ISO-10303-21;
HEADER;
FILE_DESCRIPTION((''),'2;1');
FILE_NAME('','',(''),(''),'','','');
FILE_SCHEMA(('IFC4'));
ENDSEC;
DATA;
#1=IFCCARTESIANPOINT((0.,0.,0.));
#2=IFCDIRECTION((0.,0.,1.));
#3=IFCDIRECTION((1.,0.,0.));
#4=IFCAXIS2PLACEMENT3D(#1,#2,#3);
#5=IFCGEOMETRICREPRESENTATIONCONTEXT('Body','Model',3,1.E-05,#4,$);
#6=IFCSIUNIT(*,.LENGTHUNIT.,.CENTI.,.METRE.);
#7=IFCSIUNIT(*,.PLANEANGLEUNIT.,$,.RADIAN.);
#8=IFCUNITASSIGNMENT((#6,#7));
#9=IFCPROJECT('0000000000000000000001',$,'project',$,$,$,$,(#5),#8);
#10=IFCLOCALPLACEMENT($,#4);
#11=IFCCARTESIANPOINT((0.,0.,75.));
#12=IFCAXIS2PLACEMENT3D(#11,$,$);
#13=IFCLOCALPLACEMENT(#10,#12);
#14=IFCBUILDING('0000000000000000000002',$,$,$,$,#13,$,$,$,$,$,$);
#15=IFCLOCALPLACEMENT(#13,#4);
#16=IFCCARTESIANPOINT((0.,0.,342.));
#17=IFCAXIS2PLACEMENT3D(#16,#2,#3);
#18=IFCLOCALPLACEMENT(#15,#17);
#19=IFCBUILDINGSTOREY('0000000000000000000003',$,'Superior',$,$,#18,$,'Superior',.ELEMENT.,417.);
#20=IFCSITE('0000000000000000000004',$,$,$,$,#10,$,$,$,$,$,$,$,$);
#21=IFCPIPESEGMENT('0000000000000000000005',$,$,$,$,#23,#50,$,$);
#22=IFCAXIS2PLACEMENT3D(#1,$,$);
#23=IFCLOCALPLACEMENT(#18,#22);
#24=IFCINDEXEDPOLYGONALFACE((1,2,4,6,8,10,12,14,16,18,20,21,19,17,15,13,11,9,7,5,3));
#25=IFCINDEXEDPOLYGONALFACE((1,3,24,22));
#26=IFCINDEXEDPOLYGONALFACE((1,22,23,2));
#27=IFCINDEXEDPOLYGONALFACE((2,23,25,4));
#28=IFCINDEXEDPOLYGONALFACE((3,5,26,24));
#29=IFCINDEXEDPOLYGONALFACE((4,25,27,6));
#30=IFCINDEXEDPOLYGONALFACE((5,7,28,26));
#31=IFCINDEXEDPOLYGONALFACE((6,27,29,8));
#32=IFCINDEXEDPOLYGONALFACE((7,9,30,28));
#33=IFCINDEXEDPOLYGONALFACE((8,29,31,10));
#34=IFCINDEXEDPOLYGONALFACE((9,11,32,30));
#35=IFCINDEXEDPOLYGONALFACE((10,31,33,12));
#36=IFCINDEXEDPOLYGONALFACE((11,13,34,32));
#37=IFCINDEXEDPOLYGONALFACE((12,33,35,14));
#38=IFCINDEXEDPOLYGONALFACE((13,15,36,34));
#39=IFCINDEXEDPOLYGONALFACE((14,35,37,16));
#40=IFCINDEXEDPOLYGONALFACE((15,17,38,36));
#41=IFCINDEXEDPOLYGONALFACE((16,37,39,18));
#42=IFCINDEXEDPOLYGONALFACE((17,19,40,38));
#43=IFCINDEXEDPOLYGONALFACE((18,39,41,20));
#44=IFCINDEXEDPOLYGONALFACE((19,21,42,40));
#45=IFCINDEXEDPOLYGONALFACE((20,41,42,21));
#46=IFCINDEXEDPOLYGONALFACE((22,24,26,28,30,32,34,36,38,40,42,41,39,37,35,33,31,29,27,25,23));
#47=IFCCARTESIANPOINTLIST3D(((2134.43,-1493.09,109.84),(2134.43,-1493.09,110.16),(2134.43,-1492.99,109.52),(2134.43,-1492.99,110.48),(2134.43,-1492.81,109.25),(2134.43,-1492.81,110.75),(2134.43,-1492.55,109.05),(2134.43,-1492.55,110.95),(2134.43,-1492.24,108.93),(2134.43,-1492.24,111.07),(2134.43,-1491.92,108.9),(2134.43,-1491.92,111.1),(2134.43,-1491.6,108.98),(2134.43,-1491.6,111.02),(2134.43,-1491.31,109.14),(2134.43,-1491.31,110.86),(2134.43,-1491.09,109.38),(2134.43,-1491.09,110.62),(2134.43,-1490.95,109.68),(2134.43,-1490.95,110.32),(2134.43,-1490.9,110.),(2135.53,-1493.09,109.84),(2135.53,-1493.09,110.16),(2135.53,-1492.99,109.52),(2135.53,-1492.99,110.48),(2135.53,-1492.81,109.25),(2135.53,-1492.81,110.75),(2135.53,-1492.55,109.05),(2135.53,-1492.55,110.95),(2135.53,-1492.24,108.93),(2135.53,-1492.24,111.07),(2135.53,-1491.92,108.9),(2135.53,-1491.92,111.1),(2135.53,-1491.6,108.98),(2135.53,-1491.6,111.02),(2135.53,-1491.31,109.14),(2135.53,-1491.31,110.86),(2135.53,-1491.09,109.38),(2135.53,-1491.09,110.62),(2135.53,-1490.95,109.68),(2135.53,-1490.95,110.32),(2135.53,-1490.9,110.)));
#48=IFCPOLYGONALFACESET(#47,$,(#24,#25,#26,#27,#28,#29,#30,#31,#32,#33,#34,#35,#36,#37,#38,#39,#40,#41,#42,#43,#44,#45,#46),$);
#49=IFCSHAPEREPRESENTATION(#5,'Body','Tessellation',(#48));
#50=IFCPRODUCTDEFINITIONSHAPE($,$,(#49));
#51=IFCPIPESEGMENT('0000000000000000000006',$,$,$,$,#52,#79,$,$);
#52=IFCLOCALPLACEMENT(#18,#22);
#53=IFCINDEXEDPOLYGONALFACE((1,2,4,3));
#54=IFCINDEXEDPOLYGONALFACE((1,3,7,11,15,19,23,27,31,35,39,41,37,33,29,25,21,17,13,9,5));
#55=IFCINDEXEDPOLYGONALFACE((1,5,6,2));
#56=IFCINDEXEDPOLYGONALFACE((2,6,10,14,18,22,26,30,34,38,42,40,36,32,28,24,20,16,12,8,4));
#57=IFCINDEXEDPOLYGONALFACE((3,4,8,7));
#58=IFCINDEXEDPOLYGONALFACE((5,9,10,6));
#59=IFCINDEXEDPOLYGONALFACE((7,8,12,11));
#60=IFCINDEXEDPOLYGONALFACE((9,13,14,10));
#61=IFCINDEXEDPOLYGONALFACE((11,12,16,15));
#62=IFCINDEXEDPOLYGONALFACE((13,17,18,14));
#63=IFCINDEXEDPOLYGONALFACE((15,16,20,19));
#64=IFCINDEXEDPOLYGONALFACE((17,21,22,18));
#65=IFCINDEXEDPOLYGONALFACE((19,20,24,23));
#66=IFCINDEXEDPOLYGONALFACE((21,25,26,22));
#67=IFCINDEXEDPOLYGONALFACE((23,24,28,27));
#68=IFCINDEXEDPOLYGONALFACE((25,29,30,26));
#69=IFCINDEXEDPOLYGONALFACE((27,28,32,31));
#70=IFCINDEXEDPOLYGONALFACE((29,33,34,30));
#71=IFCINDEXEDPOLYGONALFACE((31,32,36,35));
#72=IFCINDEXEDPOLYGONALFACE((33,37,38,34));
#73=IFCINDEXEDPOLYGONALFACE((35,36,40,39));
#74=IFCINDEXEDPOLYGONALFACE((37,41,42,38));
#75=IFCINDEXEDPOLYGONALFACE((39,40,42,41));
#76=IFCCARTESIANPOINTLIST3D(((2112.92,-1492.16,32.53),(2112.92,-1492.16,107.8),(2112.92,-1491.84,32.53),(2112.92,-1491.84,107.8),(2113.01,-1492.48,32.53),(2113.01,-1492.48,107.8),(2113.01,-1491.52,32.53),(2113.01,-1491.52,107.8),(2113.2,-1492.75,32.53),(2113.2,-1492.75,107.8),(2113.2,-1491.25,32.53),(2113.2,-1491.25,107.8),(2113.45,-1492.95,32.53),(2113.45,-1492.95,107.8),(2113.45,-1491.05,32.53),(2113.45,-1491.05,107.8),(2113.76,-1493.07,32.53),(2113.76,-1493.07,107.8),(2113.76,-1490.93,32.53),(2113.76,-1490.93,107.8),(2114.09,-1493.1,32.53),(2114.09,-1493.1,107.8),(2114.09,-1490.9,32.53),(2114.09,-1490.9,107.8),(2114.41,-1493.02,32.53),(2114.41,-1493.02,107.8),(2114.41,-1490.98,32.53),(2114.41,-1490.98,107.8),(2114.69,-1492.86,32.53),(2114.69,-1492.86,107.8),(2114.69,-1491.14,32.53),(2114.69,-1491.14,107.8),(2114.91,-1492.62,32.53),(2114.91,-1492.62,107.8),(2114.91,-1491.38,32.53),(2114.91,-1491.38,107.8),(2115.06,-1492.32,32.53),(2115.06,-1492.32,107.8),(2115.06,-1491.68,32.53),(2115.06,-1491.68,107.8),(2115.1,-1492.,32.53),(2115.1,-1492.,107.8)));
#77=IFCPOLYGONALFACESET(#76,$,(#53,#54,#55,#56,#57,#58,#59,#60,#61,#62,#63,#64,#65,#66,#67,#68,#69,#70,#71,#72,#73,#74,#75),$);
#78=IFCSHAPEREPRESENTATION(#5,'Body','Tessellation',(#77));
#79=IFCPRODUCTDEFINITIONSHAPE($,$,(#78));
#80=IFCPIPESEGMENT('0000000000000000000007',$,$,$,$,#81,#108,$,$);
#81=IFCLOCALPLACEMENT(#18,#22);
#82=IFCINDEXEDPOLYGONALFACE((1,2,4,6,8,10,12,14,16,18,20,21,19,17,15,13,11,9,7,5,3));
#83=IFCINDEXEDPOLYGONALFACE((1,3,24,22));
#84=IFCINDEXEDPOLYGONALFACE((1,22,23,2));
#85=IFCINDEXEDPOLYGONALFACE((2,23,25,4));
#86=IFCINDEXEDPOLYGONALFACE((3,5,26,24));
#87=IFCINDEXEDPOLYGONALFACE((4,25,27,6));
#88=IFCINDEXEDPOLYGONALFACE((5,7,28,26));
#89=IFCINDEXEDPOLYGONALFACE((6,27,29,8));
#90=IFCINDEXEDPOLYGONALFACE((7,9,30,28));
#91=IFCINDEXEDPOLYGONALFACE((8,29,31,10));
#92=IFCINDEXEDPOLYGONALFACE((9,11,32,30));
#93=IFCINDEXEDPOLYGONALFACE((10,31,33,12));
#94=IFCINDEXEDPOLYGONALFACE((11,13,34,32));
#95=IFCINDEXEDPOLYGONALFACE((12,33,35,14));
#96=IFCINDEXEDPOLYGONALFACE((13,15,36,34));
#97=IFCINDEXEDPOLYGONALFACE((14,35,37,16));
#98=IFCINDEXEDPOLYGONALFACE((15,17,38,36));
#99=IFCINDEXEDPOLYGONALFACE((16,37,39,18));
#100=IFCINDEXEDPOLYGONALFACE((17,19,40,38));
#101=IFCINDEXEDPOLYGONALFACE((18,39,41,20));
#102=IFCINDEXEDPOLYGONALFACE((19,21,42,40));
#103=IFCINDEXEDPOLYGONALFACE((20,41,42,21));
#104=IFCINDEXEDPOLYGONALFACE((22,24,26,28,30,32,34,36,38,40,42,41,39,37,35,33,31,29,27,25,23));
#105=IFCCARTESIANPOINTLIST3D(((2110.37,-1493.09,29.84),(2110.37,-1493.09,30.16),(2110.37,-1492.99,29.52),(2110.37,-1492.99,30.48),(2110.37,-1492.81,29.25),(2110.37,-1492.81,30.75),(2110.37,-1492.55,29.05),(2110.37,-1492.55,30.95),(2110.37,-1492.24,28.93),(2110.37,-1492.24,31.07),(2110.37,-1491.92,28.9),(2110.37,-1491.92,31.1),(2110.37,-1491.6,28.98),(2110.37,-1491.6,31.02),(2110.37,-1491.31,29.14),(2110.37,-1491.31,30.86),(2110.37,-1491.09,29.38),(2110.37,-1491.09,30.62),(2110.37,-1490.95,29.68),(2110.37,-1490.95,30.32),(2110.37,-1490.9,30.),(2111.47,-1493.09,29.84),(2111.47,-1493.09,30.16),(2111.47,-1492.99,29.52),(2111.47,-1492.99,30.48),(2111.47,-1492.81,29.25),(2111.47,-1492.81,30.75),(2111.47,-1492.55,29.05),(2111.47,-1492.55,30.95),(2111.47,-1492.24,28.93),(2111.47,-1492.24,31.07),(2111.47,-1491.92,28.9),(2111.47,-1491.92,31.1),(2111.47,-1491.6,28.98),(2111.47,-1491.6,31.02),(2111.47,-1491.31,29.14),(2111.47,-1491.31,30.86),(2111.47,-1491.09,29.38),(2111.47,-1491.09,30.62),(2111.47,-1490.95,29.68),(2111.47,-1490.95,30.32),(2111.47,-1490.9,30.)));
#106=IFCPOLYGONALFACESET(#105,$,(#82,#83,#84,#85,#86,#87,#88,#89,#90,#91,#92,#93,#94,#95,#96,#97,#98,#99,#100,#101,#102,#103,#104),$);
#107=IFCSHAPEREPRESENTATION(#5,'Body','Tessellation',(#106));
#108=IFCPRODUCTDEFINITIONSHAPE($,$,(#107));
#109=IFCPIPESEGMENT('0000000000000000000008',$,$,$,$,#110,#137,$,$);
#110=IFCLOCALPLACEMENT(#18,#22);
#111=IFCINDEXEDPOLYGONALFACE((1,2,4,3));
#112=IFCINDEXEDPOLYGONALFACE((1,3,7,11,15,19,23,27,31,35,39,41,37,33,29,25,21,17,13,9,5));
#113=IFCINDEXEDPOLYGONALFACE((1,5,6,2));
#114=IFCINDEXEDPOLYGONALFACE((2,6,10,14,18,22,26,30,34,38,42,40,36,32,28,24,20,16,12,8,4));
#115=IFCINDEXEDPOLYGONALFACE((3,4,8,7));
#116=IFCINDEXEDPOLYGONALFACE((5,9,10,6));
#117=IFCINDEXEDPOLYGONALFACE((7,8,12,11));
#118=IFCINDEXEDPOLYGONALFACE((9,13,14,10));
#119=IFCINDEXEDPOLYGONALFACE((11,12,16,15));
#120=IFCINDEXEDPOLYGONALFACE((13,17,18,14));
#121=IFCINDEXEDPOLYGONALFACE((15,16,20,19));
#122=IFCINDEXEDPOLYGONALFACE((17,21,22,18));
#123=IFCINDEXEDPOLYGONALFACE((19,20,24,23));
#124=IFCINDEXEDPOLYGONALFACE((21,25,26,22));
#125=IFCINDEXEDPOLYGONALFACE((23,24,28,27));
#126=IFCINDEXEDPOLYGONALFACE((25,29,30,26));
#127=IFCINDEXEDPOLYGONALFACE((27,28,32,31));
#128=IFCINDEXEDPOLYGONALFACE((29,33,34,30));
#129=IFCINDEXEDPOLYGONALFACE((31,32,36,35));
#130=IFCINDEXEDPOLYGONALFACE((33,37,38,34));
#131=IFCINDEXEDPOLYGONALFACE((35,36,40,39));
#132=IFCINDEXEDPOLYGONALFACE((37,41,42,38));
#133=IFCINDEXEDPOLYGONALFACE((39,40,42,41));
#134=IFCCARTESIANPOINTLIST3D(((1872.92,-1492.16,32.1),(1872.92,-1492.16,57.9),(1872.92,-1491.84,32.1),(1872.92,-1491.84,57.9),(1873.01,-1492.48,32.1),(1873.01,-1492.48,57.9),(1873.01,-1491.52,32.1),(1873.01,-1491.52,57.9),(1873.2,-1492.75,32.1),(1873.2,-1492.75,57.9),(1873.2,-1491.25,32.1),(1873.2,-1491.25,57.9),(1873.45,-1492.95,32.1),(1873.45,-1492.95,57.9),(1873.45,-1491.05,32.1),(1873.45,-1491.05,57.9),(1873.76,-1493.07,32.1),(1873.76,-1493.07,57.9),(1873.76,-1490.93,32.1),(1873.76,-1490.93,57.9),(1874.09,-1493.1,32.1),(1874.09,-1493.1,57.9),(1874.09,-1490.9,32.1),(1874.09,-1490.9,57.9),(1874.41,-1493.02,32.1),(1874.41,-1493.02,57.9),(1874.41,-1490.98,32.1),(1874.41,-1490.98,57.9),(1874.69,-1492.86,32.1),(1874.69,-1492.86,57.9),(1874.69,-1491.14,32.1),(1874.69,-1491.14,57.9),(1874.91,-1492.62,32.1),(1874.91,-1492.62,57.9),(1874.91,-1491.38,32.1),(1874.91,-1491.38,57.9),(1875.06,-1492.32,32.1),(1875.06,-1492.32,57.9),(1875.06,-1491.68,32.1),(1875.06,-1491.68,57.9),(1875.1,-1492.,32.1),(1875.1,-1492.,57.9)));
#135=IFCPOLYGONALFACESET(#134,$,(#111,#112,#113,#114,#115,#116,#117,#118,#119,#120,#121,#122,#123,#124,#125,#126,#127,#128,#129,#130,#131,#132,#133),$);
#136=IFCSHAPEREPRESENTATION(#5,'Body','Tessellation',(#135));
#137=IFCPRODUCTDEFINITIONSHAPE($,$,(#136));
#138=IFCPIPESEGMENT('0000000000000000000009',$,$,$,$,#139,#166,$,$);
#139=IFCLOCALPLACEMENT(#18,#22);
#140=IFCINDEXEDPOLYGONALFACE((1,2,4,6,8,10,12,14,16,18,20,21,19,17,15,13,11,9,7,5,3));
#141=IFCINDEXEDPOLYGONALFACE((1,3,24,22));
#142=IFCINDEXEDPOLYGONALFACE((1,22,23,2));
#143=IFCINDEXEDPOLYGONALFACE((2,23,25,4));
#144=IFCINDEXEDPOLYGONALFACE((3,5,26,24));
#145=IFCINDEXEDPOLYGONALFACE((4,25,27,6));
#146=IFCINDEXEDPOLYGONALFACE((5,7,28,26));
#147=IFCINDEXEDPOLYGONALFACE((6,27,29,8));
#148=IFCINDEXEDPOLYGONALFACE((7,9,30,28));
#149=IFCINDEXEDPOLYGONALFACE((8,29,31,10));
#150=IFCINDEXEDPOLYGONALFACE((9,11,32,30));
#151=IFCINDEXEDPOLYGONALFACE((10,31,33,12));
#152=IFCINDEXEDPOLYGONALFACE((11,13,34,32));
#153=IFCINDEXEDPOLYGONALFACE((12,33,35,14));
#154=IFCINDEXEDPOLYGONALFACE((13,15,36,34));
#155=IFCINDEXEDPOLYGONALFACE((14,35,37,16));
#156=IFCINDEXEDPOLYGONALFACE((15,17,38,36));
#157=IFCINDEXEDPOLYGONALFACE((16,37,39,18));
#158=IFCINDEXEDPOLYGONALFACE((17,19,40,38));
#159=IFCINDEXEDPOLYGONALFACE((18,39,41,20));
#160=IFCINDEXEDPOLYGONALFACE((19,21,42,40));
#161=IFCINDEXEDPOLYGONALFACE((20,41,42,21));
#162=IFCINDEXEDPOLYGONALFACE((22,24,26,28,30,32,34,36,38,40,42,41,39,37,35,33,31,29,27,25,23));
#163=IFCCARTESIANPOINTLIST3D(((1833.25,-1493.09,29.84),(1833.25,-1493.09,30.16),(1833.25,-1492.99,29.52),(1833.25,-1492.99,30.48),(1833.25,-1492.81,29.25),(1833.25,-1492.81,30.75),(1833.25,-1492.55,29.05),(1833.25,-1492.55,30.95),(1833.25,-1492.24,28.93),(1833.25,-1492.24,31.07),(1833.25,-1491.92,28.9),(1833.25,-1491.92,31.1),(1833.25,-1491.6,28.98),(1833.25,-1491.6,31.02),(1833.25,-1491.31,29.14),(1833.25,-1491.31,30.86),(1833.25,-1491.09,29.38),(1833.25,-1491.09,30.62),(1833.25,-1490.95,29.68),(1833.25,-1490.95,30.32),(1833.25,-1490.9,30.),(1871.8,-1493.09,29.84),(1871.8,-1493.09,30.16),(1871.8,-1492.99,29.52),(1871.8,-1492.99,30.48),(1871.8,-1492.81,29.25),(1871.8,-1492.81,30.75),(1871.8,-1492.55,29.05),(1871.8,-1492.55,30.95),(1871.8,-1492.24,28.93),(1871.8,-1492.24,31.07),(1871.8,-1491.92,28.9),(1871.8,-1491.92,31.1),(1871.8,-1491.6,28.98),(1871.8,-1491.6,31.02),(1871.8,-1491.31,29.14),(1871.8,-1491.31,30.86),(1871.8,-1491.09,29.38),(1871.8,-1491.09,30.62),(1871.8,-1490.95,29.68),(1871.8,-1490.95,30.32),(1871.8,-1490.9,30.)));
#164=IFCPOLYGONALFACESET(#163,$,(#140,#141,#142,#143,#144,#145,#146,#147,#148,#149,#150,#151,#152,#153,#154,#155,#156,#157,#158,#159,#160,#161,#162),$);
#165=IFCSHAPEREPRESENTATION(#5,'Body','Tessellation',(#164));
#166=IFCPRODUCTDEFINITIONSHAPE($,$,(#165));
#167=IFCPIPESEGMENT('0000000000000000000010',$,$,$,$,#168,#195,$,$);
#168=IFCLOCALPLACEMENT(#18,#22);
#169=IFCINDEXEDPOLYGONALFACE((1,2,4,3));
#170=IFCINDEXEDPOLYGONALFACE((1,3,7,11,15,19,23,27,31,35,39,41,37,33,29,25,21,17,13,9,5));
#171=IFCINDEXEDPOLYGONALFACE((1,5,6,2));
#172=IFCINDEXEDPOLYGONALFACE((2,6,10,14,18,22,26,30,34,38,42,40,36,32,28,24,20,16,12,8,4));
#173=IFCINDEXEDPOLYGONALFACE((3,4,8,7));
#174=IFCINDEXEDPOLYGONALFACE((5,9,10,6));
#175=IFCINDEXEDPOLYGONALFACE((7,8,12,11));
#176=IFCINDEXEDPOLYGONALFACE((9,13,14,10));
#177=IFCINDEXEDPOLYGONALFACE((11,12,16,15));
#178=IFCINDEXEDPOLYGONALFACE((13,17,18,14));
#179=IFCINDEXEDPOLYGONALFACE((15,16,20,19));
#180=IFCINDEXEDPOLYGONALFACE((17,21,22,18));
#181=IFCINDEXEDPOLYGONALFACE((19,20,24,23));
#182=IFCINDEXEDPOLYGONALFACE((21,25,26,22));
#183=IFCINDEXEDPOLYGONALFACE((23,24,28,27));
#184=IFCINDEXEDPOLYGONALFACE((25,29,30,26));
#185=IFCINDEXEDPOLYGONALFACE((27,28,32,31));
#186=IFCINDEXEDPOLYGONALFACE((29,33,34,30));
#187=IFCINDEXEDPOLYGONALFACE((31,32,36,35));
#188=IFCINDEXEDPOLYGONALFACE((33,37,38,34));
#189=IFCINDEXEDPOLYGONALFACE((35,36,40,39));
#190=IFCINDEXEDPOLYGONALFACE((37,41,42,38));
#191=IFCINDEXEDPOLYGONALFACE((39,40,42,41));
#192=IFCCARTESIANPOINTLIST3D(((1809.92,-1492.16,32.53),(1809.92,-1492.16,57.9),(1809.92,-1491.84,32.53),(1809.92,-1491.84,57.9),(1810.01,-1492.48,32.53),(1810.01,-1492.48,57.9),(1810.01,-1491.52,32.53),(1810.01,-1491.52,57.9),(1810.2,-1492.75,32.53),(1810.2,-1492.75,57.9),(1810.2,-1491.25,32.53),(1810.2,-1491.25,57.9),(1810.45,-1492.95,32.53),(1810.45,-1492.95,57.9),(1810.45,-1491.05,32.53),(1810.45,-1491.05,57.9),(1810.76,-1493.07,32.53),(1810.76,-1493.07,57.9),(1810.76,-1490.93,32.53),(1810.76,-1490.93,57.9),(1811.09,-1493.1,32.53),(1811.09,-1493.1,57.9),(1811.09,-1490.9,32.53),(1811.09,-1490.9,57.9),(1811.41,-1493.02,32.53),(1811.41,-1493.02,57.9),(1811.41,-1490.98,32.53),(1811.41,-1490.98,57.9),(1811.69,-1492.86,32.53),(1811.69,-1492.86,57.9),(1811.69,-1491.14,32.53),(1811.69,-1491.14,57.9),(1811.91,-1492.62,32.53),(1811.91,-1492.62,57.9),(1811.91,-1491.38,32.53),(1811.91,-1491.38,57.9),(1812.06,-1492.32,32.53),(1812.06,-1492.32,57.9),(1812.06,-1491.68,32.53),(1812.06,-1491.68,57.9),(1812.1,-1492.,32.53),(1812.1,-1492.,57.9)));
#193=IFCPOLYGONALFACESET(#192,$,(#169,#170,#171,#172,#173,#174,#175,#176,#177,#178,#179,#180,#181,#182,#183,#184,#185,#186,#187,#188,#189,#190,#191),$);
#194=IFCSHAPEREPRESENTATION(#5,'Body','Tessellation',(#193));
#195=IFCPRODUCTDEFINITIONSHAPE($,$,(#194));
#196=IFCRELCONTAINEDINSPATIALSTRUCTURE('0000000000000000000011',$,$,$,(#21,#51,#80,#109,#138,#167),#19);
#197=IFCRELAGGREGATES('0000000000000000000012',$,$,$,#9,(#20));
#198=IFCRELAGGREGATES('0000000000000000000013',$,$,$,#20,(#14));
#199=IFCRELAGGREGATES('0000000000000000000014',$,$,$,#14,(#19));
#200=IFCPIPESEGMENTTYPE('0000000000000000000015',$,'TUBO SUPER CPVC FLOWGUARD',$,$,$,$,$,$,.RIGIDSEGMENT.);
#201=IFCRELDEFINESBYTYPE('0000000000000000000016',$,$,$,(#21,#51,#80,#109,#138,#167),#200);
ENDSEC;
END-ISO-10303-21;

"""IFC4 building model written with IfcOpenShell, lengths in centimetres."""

from ifc_helpers import new_model, si_unit, frame, origin_with_axes, origin_2d_with_axis, place, context, project, spatial, circle, extrude, type_object, element, save


model = new_model("IFC4")

# Units and contexts
model_context = context("Model", 3, precision=1e-05, world=origin_with_axes(), identifier="Body")
ifc_project = project(units=[si_unit("LENGTHUNIT", "METRE", prefix="CENTI"), si_unit("PLANEANGLEUNIT", "RADIAN")], contexts=[model_context])

# Site, building, storey
site_placement = place(None, origin_with_axes())
site = spatial("IfcSite", under=ifc_project, at=site_placement)
building_placement = place(site_placement, frame((0.0, 0.0, 75.0)))
building = spatial("IfcBuilding", under=site, at=building_placement)
placement = place(building_placement, origin_with_axes())
storey_placement = place(placement, frame((0.0, 0.0, 342.0), z_axis=(0.0, 0.0, 1.0), x_axis=(1.0, 0.0, 0.0)))
storey = spatial("IfcBuildingStorey", under=building, at=storey_placement, Name="Superior", LongName="Superior", CompositionType="ELEMENT", Elevation=417.0)

# Pipe segments
pipe_segment_type_1 = type_object("IfcPipeSegmentType", Name="TUBO SUPER CPVC FLOWGUARD", PredefinedType="RIGIDSEGMENT")
pipe_segment_1_placement = place(storey_placement, frame((2134.98, -1492.0, 111.1), z_axis=(0.0, 0.0, 1.0), x_axis=(1.0, 0.0, 0.0)))
element("IfcPipeSegment", 1, at=pipe_segment_1_placement, inside=storey, type_object=pipe_segment_type_1, context=model_context, shape_type="SolidModel", body=[
    extrude(circle(Radius=1.1, at=origin_2d_with_axis()), frame((0.55, 0.0, -1.1), z_axis=(-1.0, 0.0, 0.0), x_axis=(0.0, 1.0, 0.0)), (0.0, 0.0, 1.0), 1.1),
])
pipe_segment_2_placement = place(storey_placement, frame((2114.0, -1492.0, 107.8), z_axis=(0.0, 0.0, 1.0), x_axis=(1.0, 0.0, 0.0)))
element("IfcPipeSegment", 2, at=pipe_segment_2_placement, inside=storey, type_object=pipe_segment_type_1, context=model_context, shape_type="SolidModel", body=[
    extrude(circle(Radius=1.1, at=origin_2d_with_axis()), frame((0.0, 0.0, 0.0), z_axis=(0.0, 0.0, -1.0), x_axis=(1.0, 0.0, 0.0)), (0.0, 0.0, 1.0), 75.27),
])
pipe_segment_3_placement = place(storey_placement, frame((2110.92, -1492.0, 31.1), z_axis=(0.0, 0.0, 1.0), x_axis=(1.0, 0.0, 0.0)))
element("IfcPipeSegment", 3, at=pipe_segment_3_placement, inside=storey, type_object=pipe_segment_type_1, context=model_context, shape_type="SolidModel", body=[
    extrude(circle(Radius=1.1, at=origin_2d_with_axis()), frame((0.55, 0.0, -1.1), z_axis=(-1.0, 0.0, 0.0), x_axis=(0.0, 1.0, 0.0)), (0.0, 0.0, 1.0), 1.1),
])
pipe_segment_4_placement = place(storey_placement, frame((1874.0, -1492.0, 57.9), z_axis=(0.0, 0.0, 1.0), x_axis=(1.0, 0.0, 0.0)))
element("IfcPipeSegment", 4, at=pipe_segment_4_placement, inside=storey, type_object=pipe_segment_type_1, context=model_context, shape_type="SolidModel", body=[
    extrude(circle(Radius=1.1, at=origin_2d_with_axis()), frame((0.0, 0.0, -25.8), z_axis=(0.0, 0.0, 1.0), x_axis=(1.0, 0.0, 0.0)), (0.0, 0.0, 1.0), 25.8),
])
pipe_segment_5_placement = place(storey_placement, frame((1852.53, -1492.0, 31.1), z_axis=(0.0, 0.0, 1.0), x_axis=(1.0, 0.0, 0.0)))
element("IfcPipeSegment", 5, at=pipe_segment_5_placement, inside=storey, type_object=pipe_segment_type_1, context=model_context, shape_type="SolidModel", body=[
    extrude(circle(Radius=1.1, at=origin_2d_with_axis()), frame((19.28, 0.0, -1.1), z_axis=(-1.0, 0.0, 0.0), x_axis=(0.0, 1.0, 0.0)), (0.0, 0.0, 1.0), 38.55),
])
pipe_segment_6_placement = place(storey_placement, frame((1811.0, -1492.0, 57.9), z_axis=(0.0, 0.0, 1.0), x_axis=(1.0, 0.0, 0.0)))
element("IfcPipeSegment", 6, at=pipe_segment_6_placement, inside=storey, type_object=pipe_segment_type_1, context=model_context, shape_type="SolidModel", body=[
    extrude(circle(Radius=1.1, at=origin_2d_with_axis()), frame((0.0, 0.0, -25.37), z_axis=(0.0, 0.0, 1.0), x_axis=(1.0, 0.0, 0.0)), (0.0, 0.0, 1.0), 25.37),
])

save(model, "model.ifc")
